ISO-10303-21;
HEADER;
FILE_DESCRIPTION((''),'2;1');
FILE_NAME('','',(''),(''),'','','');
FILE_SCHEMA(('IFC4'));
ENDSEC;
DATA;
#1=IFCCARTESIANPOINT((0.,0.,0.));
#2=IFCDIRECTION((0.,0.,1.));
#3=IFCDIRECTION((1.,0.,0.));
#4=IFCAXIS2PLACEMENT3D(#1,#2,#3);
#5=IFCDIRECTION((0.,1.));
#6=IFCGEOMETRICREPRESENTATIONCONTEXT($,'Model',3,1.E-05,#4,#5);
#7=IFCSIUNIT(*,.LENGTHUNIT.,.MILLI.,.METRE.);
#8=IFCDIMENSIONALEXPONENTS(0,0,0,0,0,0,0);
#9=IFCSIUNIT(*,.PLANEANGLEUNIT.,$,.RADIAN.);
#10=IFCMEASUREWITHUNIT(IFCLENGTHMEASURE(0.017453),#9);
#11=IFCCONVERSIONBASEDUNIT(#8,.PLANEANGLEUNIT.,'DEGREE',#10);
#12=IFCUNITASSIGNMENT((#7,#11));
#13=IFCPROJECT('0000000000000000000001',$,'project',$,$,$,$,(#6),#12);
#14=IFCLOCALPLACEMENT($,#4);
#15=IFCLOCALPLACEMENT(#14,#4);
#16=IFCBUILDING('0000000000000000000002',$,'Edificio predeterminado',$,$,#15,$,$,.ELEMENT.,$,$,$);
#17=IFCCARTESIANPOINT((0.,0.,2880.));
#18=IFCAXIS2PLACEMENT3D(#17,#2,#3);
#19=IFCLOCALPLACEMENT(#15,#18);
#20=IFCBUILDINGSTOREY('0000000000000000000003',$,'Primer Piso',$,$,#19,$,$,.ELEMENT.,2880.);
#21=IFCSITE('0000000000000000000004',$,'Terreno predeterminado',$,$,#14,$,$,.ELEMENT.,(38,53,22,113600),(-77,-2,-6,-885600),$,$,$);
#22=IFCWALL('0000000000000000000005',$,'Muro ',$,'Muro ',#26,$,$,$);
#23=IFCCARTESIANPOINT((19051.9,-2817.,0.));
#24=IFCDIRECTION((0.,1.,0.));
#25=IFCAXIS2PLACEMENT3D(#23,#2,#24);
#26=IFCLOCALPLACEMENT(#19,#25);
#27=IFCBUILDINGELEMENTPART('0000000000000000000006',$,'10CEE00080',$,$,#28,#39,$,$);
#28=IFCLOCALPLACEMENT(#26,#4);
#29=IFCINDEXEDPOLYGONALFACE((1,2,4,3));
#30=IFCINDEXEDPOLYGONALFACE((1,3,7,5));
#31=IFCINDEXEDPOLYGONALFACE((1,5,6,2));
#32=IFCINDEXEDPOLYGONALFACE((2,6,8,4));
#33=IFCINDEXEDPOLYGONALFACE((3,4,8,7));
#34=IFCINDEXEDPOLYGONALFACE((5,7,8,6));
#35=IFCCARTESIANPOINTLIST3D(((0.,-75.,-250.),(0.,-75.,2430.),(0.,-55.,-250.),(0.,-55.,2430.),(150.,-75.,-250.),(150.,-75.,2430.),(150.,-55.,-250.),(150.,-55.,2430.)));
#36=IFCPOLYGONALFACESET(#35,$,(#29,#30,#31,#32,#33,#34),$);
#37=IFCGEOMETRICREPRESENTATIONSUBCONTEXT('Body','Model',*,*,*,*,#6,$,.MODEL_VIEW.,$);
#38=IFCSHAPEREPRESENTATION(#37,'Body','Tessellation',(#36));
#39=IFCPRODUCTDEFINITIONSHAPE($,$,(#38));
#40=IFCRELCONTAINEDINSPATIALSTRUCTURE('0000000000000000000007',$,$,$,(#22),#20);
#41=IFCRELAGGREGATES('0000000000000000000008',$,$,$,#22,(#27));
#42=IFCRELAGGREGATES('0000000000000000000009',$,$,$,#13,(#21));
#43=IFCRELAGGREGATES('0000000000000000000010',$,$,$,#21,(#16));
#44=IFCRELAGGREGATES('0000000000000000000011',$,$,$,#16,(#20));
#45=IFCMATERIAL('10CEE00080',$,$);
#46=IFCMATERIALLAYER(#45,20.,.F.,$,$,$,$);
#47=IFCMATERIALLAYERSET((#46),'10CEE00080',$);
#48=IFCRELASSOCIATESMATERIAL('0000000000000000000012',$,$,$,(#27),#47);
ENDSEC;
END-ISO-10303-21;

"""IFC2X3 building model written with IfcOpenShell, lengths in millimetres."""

from ifc_helpers import new_model, entity, si_unit, converted_unit, direction, frame, origin_with_axes, place, context, subcontext, project, spatial, polyline, outline, extrude, clip, bounded_halfspace, material, layer, layer_set, layer_usage, element, aggregate, save


model = new_model("IFC2X3")

# Units and contexts
model_context = context("Model", 3, precision=1e-05, world=origin_with_axes(), true_north=direction((0.0, 1.0)))
body_context = subcontext(model_context, "Body", "Model", "MODEL_VIEW")
ifc_project = project(units=[si_unit("LENGTHUNIT", "METRE", prefix="MILLI"), converted_unit("PLANEANGLEUNIT", "DEGREE", entity("IfcLengthMeasure", 0.017453), si_unit("PLANEANGLEUNIT", "RADIAN"), dimensions=[0, 0, 0, 0, 0, 0, 0])], contexts=[model_context])

# Site, building, storey
site_placement = place(None, origin_with_axes())
site = spatial("IfcSite", under=ifc_project, at=site_placement, Name="Terreno predeterminado", CompositionType="ELEMENT", RefLatitude=(38, 53, 22, 113600), RefLongitude=(-77, -2, -6, -885600))
building_placement = place(site_placement, origin_with_axes())
building = spatial("IfcBuilding", under=site, at=building_placement, Name="Edificio predeterminado", CompositionType="ELEMENT")
storey_placement = place(building_placement, frame((0.0, 0.0, 2880.0), z_axis=(0.0, 0.0, 1.0), x_axis=(1.0, 0.0, 0.0)))
storey = spatial("IfcBuildingStorey", under=building, at=storey_placement, Name="Primer Piso", CompositionType="ELEMENT", Elevation=2880.0)

# Wall, building element part
wall_1_placement = place(storey_placement, frame((19051.9, -2817.0, 0.0), z_axis=(0.0, 0.0, 1.0), x_axis=(0.0, 1.0, 0.0)))
wall_1 = element("IfcWall", 1, at=wall_1_placement, inside=storey, Name="Muro ", ObjectType="Muro ")
ifc_material_1 = material(Name="10CEE00080")
ifc_layer_1 = layer(ifc_material_1, 20.0, ventilated=False)
ifc_layer_set_1 = layer_set([ifc_layer_1], Name="10CEE00080")
ifc_layer_usage_1 = layer_usage(ifc_layer_set_1, "AXIS2", "NEGATIVE", 55.0)
building_element_part_1_placement = place(wall_1_placement, origin_with_axes())
building_element_part_1 = element("IfcBuildingElementPart", 2, at=building_element_part_1_placement, material=ifc_layer_usage_1, Name="10CEE00080", context=body_context, shape_type="Clipping", body=[
    clip(clip(extrude(outline(polyline([(150.0, -55.0), (150.0, -75.0), (0.0, -75.0), (0.0, -55.0), (150.0, -55.0)])), frame((0.0, 0.0, -250.0), z_axis=(0.0, 0.0, 1.0), x_axis=(1.0, 0.0, 0.0)), (0.0, 0.0, 1.0), 2680.0), bounded_halfspace(frame((0.0, 0.0, -250.0), z_axis=(0.0, 0.0, 1.0), x_axis=(1.0, 0.0, 0.0)), True, origin_with_axes(), polyline([(-150.0, -150.0), (375.0, -150.0), (375.0, 150.0), (-150.0, 150.0), (-150.0, -150.0)]))), bounded_halfspace(frame((0.0, 0.0, 2430.0), z_axis=(0.0, 0.0, 1.0), x_axis=(1.0, 0.0, 0.0)), False, origin_with_axes(), polyline([(-150.0, -150.0), (375.0, -150.0), (375.0, 150.0), (-150.0, 150.0), (-150.0, -150.0)]))),
])
aggregate(wall_1, [building_element_part_1])

save(model, "model.ifc")
